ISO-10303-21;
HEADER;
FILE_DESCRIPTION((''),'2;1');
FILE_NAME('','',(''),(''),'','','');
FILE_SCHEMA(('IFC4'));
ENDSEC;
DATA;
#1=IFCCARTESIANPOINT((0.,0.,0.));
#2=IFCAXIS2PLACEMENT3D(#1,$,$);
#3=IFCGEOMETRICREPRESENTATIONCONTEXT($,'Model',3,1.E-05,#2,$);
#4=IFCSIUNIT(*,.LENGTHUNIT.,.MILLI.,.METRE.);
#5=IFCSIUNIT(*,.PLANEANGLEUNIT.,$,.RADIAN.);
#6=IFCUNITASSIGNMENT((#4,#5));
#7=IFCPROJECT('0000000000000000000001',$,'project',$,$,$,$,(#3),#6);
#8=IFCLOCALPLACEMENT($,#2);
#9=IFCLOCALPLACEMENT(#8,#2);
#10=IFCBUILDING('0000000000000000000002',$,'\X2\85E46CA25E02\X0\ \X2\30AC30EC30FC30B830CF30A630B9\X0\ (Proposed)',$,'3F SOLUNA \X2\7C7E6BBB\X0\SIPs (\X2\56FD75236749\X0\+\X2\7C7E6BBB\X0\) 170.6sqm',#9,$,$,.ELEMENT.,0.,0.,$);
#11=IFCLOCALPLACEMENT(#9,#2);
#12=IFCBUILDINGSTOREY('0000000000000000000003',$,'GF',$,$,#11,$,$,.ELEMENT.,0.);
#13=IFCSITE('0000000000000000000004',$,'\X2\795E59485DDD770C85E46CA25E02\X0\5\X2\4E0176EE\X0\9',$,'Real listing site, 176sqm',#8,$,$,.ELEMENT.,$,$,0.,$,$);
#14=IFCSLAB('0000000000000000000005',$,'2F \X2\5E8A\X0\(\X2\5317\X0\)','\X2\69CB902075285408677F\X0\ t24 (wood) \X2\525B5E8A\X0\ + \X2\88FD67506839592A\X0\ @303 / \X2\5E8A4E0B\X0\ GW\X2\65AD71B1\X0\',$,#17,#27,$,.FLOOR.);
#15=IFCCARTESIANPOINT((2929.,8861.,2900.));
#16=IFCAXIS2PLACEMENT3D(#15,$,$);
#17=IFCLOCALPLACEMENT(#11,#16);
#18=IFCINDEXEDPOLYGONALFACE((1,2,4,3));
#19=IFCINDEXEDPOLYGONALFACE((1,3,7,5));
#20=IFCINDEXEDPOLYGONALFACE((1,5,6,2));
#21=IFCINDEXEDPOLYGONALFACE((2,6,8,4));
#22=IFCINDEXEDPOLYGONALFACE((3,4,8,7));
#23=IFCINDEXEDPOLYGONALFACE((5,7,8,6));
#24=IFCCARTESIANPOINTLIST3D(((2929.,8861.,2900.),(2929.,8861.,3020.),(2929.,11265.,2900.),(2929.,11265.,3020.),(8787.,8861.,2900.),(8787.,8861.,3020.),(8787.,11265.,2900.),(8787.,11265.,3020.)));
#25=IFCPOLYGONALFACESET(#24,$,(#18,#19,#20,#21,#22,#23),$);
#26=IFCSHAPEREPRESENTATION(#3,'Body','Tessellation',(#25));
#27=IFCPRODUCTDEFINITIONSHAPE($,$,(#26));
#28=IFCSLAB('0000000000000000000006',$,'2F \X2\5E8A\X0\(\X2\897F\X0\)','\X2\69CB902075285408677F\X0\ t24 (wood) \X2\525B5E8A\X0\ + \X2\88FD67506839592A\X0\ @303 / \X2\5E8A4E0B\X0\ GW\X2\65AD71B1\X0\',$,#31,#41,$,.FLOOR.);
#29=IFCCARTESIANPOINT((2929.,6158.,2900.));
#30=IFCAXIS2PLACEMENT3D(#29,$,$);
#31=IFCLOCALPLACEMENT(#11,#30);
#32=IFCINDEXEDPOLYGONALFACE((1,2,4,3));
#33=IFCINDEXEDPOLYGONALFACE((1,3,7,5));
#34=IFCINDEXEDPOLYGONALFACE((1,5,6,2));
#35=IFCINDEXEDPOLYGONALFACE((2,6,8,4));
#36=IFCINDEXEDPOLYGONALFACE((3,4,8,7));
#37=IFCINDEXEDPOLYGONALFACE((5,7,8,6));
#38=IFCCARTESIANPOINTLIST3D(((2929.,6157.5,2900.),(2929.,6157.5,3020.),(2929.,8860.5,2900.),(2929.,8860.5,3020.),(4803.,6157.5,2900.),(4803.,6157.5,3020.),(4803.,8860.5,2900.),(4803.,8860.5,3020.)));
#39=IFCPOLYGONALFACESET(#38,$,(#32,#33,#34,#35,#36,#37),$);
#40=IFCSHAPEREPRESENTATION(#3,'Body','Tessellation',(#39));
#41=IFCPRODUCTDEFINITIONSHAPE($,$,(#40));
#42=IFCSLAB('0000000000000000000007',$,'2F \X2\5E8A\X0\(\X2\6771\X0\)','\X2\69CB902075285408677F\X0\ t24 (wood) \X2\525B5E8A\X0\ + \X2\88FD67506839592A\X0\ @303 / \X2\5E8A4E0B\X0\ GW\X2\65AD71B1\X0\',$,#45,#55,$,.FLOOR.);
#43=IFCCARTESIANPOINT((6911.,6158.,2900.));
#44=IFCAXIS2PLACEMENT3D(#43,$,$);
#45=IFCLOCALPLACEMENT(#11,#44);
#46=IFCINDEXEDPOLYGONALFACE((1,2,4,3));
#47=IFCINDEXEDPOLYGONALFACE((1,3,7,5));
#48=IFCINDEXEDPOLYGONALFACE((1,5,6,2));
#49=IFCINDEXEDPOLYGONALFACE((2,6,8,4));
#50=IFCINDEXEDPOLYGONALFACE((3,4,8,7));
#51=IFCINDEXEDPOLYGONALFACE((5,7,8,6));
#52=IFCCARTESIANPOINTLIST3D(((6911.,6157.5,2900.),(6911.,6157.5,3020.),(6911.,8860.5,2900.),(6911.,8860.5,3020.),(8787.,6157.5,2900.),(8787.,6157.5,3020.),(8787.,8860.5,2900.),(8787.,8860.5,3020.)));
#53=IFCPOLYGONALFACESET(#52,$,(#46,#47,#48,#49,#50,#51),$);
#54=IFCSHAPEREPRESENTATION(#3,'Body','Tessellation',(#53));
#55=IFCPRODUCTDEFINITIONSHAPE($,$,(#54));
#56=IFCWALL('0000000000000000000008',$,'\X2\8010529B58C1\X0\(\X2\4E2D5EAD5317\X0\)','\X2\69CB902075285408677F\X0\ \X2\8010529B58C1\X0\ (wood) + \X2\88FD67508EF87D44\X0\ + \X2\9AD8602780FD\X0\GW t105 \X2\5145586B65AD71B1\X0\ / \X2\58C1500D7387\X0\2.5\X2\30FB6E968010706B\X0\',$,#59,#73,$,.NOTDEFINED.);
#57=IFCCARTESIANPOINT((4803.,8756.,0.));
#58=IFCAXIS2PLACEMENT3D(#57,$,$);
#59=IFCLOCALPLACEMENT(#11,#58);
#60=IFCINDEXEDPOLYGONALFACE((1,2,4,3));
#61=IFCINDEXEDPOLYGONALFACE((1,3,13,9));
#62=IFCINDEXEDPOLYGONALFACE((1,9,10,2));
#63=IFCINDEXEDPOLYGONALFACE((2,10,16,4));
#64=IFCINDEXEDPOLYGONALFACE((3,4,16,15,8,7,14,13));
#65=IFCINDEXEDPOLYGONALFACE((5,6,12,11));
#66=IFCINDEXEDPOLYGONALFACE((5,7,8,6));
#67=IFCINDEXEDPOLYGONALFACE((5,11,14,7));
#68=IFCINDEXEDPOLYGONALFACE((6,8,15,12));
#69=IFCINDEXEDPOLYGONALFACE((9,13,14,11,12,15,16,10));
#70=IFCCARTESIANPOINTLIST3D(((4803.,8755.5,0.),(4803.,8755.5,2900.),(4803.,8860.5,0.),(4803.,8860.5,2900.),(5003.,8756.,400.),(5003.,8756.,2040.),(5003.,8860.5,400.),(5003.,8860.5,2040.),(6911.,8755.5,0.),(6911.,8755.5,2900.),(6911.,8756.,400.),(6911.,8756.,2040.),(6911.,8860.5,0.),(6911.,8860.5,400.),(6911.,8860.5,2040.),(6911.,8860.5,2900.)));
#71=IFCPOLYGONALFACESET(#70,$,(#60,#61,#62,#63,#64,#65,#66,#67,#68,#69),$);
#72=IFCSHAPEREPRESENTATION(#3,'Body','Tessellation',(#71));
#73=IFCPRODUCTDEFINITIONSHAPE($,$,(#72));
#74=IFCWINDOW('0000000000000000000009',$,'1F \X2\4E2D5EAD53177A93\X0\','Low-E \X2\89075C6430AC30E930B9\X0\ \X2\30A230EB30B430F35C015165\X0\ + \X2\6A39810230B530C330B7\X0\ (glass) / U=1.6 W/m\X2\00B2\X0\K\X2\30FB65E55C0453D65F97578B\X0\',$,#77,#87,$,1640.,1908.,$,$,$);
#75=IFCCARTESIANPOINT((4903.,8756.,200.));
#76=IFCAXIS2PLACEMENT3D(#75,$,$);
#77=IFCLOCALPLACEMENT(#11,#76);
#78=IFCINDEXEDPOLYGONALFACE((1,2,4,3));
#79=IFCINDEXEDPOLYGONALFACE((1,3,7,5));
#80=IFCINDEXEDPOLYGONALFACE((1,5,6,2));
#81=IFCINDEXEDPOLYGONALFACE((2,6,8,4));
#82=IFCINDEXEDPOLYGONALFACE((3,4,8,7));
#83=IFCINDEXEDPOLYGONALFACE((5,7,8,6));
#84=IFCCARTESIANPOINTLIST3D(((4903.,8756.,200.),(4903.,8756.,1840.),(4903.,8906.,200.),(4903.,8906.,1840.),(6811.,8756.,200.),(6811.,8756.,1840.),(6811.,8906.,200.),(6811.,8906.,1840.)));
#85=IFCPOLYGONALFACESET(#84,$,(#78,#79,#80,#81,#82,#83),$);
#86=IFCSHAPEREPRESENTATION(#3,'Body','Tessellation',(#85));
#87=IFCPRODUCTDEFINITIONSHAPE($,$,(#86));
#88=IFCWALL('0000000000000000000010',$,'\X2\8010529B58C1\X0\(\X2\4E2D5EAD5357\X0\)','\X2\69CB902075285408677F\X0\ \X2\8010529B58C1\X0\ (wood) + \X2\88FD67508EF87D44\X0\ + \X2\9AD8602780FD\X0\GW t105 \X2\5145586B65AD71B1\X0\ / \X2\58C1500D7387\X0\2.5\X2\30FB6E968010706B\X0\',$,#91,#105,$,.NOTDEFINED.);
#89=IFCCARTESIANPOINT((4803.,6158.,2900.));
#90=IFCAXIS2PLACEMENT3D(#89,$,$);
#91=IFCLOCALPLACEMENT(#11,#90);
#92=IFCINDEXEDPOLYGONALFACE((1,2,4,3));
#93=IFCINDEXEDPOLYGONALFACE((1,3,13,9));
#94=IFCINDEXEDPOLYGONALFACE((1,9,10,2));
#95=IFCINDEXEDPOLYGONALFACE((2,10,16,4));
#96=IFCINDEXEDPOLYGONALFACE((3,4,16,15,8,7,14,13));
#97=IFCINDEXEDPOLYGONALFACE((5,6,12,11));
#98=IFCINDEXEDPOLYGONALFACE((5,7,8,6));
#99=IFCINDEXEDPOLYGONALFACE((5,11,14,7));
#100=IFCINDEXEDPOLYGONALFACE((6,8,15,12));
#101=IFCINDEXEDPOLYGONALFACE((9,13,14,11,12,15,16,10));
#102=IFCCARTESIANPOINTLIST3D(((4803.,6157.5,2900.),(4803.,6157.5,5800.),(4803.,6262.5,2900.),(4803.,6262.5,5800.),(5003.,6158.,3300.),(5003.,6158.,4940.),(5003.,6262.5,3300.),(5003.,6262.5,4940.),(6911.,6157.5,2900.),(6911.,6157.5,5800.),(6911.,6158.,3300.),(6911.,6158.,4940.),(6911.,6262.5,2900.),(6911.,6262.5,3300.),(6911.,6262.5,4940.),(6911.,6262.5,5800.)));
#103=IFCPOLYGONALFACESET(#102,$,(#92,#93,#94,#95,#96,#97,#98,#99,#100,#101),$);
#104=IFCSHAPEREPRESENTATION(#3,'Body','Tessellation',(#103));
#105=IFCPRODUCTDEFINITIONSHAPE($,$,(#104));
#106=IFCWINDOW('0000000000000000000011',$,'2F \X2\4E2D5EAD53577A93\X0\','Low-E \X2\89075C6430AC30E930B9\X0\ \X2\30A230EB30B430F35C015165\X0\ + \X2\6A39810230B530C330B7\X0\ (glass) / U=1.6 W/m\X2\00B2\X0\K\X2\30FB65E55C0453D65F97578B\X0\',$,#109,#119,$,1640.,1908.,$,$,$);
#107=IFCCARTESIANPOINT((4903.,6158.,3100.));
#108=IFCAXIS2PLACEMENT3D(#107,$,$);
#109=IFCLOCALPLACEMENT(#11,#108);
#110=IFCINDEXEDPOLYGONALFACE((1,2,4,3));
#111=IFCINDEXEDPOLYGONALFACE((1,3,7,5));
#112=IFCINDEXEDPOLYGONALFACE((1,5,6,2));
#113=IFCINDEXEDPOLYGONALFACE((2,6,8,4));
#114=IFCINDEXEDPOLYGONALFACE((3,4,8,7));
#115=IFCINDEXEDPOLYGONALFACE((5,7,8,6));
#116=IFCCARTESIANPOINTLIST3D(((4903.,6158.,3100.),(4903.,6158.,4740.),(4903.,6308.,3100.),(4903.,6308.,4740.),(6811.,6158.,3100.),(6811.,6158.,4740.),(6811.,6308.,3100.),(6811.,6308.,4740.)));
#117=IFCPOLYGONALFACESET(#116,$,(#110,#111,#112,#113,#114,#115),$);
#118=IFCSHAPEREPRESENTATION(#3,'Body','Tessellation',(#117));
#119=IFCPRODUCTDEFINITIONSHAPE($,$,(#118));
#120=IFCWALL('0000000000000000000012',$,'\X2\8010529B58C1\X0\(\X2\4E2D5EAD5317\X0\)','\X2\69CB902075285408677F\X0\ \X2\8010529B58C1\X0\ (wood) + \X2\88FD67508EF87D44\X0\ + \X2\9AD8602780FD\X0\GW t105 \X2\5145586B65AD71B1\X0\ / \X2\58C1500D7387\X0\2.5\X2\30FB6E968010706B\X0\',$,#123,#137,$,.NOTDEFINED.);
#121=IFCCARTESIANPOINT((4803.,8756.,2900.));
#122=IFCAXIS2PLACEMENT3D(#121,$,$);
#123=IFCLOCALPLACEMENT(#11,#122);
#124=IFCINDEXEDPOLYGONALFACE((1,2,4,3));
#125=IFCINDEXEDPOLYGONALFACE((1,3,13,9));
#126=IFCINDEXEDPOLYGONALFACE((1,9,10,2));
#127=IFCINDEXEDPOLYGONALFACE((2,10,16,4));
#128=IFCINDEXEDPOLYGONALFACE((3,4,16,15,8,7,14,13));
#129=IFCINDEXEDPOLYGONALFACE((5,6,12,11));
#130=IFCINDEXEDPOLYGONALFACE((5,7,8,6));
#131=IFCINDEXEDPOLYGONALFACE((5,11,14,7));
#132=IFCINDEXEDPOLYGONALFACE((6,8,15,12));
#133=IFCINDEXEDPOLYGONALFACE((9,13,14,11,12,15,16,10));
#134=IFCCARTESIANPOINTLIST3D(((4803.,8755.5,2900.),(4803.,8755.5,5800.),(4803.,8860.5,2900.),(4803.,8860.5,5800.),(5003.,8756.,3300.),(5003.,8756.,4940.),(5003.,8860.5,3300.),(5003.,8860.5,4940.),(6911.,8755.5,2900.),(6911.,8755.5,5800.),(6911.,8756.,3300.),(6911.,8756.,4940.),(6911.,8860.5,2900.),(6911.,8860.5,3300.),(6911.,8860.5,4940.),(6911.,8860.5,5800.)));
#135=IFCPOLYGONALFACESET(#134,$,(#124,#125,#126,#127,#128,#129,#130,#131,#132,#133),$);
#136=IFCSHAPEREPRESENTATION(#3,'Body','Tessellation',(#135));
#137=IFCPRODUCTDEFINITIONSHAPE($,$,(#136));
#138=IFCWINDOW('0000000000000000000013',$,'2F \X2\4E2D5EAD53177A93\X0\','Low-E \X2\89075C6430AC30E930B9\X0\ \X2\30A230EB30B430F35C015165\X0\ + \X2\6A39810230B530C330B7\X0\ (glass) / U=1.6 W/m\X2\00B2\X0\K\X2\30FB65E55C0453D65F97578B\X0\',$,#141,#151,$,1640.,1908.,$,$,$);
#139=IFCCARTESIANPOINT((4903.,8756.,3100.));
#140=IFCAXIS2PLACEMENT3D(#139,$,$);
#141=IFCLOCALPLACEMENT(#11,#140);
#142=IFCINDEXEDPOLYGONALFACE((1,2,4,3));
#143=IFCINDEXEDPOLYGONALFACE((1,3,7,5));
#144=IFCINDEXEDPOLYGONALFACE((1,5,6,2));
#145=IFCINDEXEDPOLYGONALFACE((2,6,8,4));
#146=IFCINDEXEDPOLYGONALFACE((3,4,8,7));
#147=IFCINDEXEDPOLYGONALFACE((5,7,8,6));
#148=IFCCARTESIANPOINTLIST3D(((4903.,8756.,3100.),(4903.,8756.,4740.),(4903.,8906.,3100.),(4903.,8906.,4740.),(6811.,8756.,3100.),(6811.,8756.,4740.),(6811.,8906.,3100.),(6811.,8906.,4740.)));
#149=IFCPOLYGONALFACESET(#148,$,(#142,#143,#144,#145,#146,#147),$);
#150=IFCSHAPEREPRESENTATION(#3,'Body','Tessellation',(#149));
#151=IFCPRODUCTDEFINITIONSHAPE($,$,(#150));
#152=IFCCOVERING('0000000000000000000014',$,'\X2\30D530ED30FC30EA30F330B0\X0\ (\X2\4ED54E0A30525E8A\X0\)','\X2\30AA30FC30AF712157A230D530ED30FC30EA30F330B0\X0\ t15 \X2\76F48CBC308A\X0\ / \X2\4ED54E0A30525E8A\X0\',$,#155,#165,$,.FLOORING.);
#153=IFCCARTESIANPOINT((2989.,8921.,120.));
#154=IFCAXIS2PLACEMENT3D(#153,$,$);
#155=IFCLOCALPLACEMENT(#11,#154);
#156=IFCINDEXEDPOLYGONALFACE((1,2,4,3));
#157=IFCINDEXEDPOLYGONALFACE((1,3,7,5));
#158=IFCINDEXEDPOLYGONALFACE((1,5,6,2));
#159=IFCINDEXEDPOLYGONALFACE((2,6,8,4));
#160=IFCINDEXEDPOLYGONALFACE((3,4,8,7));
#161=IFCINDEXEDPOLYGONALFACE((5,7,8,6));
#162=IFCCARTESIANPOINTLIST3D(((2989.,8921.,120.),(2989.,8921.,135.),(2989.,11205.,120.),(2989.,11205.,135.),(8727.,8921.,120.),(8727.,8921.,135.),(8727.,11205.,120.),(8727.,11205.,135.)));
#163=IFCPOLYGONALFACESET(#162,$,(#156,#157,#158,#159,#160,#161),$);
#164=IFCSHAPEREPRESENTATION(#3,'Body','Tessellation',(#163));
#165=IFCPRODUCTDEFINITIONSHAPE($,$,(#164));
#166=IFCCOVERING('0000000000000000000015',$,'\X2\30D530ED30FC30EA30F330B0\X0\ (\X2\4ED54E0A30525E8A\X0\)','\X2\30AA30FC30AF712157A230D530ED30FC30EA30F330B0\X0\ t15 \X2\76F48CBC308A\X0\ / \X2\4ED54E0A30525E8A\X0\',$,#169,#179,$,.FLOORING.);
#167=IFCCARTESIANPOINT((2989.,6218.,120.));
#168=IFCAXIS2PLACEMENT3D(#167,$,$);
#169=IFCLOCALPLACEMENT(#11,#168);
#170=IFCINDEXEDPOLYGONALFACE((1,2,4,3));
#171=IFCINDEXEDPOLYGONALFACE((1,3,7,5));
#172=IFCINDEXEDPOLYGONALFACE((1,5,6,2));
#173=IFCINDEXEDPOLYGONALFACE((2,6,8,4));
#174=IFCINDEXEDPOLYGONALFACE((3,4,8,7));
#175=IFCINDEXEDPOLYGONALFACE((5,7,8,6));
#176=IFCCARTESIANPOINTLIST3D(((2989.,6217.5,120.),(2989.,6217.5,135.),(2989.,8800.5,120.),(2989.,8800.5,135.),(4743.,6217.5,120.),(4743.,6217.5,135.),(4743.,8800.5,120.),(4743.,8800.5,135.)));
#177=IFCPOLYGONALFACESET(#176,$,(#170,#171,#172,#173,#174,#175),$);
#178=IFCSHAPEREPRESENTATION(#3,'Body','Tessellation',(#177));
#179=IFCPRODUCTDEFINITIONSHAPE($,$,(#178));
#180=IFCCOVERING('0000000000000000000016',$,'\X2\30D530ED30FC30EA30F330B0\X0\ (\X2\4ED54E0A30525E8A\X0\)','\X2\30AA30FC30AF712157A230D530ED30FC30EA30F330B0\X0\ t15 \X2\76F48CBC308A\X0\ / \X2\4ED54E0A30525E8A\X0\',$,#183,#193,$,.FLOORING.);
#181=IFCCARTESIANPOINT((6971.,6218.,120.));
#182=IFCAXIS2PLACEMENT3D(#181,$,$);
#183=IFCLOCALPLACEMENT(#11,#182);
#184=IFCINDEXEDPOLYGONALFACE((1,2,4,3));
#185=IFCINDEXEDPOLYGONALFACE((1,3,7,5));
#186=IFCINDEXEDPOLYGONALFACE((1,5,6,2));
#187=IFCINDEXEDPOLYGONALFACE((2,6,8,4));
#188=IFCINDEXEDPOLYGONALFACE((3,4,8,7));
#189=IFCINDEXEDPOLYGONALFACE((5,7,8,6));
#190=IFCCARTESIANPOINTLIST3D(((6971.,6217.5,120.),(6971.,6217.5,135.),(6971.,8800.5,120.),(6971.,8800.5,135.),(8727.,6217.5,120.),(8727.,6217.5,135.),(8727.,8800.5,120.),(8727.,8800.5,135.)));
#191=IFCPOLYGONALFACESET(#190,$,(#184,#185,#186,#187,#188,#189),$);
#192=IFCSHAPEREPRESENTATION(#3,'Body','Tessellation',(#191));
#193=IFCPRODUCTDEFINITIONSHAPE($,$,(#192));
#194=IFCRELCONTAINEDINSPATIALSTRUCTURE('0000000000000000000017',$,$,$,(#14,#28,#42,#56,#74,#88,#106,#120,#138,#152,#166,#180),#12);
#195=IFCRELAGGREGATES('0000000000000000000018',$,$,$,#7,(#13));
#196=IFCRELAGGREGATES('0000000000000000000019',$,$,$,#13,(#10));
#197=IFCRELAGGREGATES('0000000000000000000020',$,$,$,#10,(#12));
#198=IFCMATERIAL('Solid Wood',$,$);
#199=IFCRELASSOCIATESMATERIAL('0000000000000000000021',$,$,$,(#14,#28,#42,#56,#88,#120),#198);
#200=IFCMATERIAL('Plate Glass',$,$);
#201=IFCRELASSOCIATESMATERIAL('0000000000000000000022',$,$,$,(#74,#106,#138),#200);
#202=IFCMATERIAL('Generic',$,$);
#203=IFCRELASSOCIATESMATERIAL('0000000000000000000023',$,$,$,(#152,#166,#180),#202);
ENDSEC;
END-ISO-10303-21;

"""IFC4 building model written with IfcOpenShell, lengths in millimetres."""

from ifc_helpers import new_model, si_unit, frame, frame_2d, origin, place, context, project, spatial, rectangle, extrude, material, element, fill, save


model = new_model("IFC4")

# Units and contexts
model_context = context("Model", 3, precision=1e-05, world=origin())
ifc_project = project(units=[si_unit("LENGTHUNIT", "METRE", prefix="MILLI"), si_unit("PLANEANGLEUNIT", "RADIAN")], contexts=[model_context])

# Site, building, storey
site_placement = place(None, origin())
site = spatial("IfcSite", under=ifc_project, at=site_placement, Name="神奈川県藤沢市5丁目9", ObjectType="Real listing site, 176sqm", CompositionType="ELEMENT", RefElevation=0.0)
building_placement = place(site_placement, origin())
building = spatial("IfcBuilding", under=site, at=building_placement, Name="藤沢市 ガレージハウス (Proposed)", ObjectType="3F SOLUNA 籾殻SIPs (国産杉+籾殻) 170.6sqm", CompositionType="ELEMENT", ElevationOfRefHeight=0.0, ElevationOfTerrain=0.0)
storey_placement = place(building_placement, origin())
storey = spatial("IfcBuildingStorey", under=building, at=storey_placement, Name="GF", CompositionType="ELEMENT", Elevation=0.0)

# Slabs
ifc_material_1 = material(Name="Solid Wood")
slab_1_placement = place(storey_placement, frame((2929.0, 8861.0, 2900.0)))
element("IfcSlab", 1, at=slab_1_placement, inside=storey, material=ifc_material_1, Name="2F 床(北)", Description="構造用合板 t24 (wood) 剛床 + 製材根太 @303 / 床下 GW断熱", PredefinedType="FLOOR", context=model_context, shape_type="SweptSolid", body=[
    extrude(rectangle(XDim=5858.0, YDim=2404.0, at=frame_2d((2929.0, 1202.0))), frame((2929.0, 8861.0, 2900.0)), (0.0, 0.0, 1.0), 120.0),
])
slab_2_placement = place(storey_placement, frame((2929.0, 6158.0, 2900.0)))
element("IfcSlab", 2, at=slab_2_placement, inside=storey, material=ifc_material_1, Name="2F 床(西)", Description="構造用合板 t24 (wood) 剛床 + 製材根太 @303 / 床下 GW断熱", PredefinedType="FLOOR", context=model_context, shape_type="SweptSolid", body=[
    extrude(rectangle(XDim=1874.0, YDim=2703.0, at=frame_2d((937.0, 1351.0))), frame((2929.0, 6158.0, 2900.0)), (0.0, 0.0, 1.0), 120.0),
])
slab_3_placement = place(storey_placement, frame((6911.0, 6158.0, 2900.0)))
element("IfcSlab", 3, at=slab_3_placement, inside=storey, material=ifc_material_1, Name="2F 床(東)", Description="構造用合板 t24 (wood) 剛床 + 製材根太 @303 / 床下 GW断熱", PredefinedType="FLOOR", context=model_context, shape_type="SweptSolid", body=[
    extrude(rectangle(XDim=1876.0, YDim=2703.0, at=frame_2d((938.0, 1351.0))), frame((6911.0, 6158.0, 2900.0)), (0.0, 0.0, 1.0), 120.0),
])

# Wall, opening, window
wall_1_placement = place(storey_placement, frame((4803.0, 8756.0, 0.0)))
wall_1 = element("IfcWall", 4, at=wall_1_placement, inside=storey, material=ifc_material_1, Name="耐力壁(中庭北)", Description="構造用合板 耐力壁 (wood) + 製材軸組 + 高性能GW t105 充填断熱 / 壁倍率2.5・準耐火", PredefinedType="NOTDEFINED", context=model_context, shape_type="SweptSolid", body=[
    extrude(rectangle(XDim=2108.0, YDim=105.0, at=frame_2d((1054.0, 52.0))), frame((4803.0, 8756.0, 0.0)), (0.0, 0.0, 1.0), 2900.0),
])
opening_1_placement = place(storey_placement, frame((4903.0, 8756.0, 200.0)))
opening_1 = element("IfcOpeningElement", 5, at=opening_1_placement, cuts=wall_1, PredefinedType="NOTDEFINED", context=model_context, shape_type="SweptSolid", body=[
    extrude(rectangle(XDim=1908.0, YDim=150.0, at=frame_2d((954.0, 75.0))), frame((4903.0, 8756.0, 200.0)), (0.0, 0.0, 1.0), 1640.0),
])
ifc_material_2 = material(Name="Plate Glass")
window_1_placement = place(storey_placement, frame((4903.0, 8756.0, 200.0)))
window_1 = element("IfcWindow", 6, at=window_1_placement, inside=storey, material=ifc_material_2, Name="1F 中庭北窓", Description="Low-E 複層ガラス アルゴン封入 + 樹脂サッシ (glass) / U=1.6 W/m²K・日射取得型", OverallHeight=1640.0, OverallWidth=1908.0, context=model_context, shape_type="SweptSolid", body=[
    extrude(rectangle(XDim=1908.0, YDim=150.0, at=frame_2d((954.0, 75.0))), frame((4903.0, 8756.0, 200.0)), (0.0, 0.0, 1.0), 1640.0),
])
fill(opening_1, window_1)

# Walls, openings, windows
wall_2_placement = place(storey_placement, frame((4803.0, 6158.0, 2900.0)))
wall_2 = element("IfcWall", 7, at=wall_2_placement, inside=storey, material=ifc_material_1, Name="耐力壁(中庭南)", Description="構造用合板 耐力壁 (wood) + 製材軸組 + 高性能GW t105 充填断熱 / 壁倍率2.5・準耐火", PredefinedType="NOTDEFINED", context=model_context, shape_type="SweptSolid", body=[
    extrude(rectangle(XDim=2108.0, YDim=105.0, at=frame_2d((1054.0, 52.0))), frame((4803.0, 6158.0, 2900.0)), (0.0, 0.0, 1.0), 2900.0),
])
opening_2_placement = place(storey_placement, frame((4903.0, 6158.0, 3100.0)))
opening_2 = element("IfcOpeningElement", 8, at=opening_2_placement, cuts=wall_2, PredefinedType="NOTDEFINED", context=model_context, shape_type="SweptSolid", body=[
    extrude(rectangle(XDim=1908.0, YDim=150.0, at=frame_2d((954.0, 75.0))), frame((4903.0, 6158.0, 3100.0)), (0.0, 0.0, 1.0), 1640.0),
])
window_2_placement = place(storey_placement, frame((4903.0, 6158.0, 3100.0)))
window_2 = element("IfcWindow", 9, at=window_2_placement, inside=storey, material=ifc_material_2, Name="2F 中庭南窓", Description="Low-E 複層ガラス アルゴン封入 + 樹脂サッシ (glass) / U=1.6 W/m²K・日射取得型", OverallHeight=1640.0, OverallWidth=1908.0, context=model_context, shape_type="SweptSolid", body=[
    extrude(rectangle(XDim=1908.0, YDim=150.0, at=frame_2d((954.0, 75.0))), frame((4903.0, 6158.0, 3100.0)), (0.0, 0.0, 1.0), 1640.0),
])
fill(opening_2, window_2)
wall_3_placement = place(storey_placement, frame((4803.0, 8756.0, 2900.0)))
wall_3 = element("IfcWall", 10, at=wall_3_placement, inside=storey, material=ifc_material_1, Name="耐力壁(中庭北)", Description="構造用合板 耐力壁 (wood) + 製材軸組 + 高性能GW t105 充填断熱 / 壁倍率2.5・準耐火", PredefinedType="NOTDEFINED", context=model_context, shape_type="SweptSolid", body=[
    extrude(rectangle(XDim=2108.0, YDim=105.0, at=frame_2d((1054.0, 52.0))), frame((4803.0, 8756.0, 2900.0)), (0.0, 0.0, 1.0), 2900.0),
])
opening_3_placement = place(storey_placement, frame((4903.0, 8756.0, 3100.0)))
opening_3 = element("IfcOpeningElement", 11, at=opening_3_placement, cuts=wall_3, PredefinedType="NOTDEFINED", context=model_context, shape_type="SweptSolid", body=[
    extrude(rectangle(XDim=1908.0, YDim=150.0, at=frame_2d((954.0, 75.0))), frame((4903.0, 8756.0, 3100.0)), (0.0, 0.0, 1.0), 1640.0),
])
window_3_placement = place(storey_placement, frame((4903.0, 8756.0, 3100.0)))
window_3 = element("IfcWindow", 12, at=window_3_placement, inside=storey, material=ifc_material_2, Name="2F 中庭北窓", Description="Low-E 複層ガラス アルゴン封入 + 樹脂サッシ (glass) / U=1.6 W/m²K・日射取得型", OverallHeight=1640.0, OverallWidth=1908.0, context=model_context, shape_type="SweptSolid", body=[
    extrude(rectangle(XDim=1908.0, YDim=150.0, at=frame_2d((954.0, 75.0))), frame((4903.0, 8756.0, 3100.0)), (0.0, 0.0, 1.0), 1640.0),
])
fill(opening_3, window_3)

# Coverings
ifc_material_3 = material(Name="Generic")
covering_1_placement = place(storey_placement, frame((2989.0, 8921.0, 120.0)))
element("IfcCovering", 13, at=covering_1_placement, inside=storey, material=ifc_material_3, Name="フローリング (仕上げ床)", Description="オーク無垢フローリング t15 直貼り / 仕上げ床", PredefinedType="FLOORING", context=model_context, shape_type="SweptSolid", body=[
    extrude(rectangle(XDim=5738.0, YDim=2284.0, at=frame_2d((2869.0, 1142.0))), frame((2989.0, 8921.0, 120.0)), (0.0, 0.0, 1.0), 15.0),
])
covering_2_placement = place(storey_placement, frame((2989.0, 6218.0, 120.0)))
element("IfcCovering", 14, at=covering_2_placement, inside=storey, material=ifc_material_3, Name="フローリング (仕上げ床)", Description="オーク無垢フローリング t15 直貼り / 仕上げ床", PredefinedType="FLOORING", context=model_context, shape_type="SweptSolid", body=[
    extrude(rectangle(XDim=1754.0, YDim=2583.0, at=frame_2d((877.0, 1291.0))), frame((2989.0, 6218.0, 120.0)), (0.0, 0.0, 1.0), 15.0),
])
covering_3_placement = place(storey_placement, frame((6971.0, 6218.0, 120.0)))
element("IfcCovering", 15, at=covering_3_placement, inside=storey, material=ifc_material_3, Name="フローリング (仕上げ床)", Description="オーク無垢フローリング t15 直貼り / 仕上げ床", PredefinedType="FLOORING", context=model_context, shape_type="SweptSolid", body=[
    extrude(rectangle(XDim=1756.0, YDim=2583.0, at=frame_2d((878.0, 1291.0))), frame((6971.0, 6218.0, 120.0)), (0.0, 0.0, 1.0), 15.0),
])

save(model, "model.ifc")
